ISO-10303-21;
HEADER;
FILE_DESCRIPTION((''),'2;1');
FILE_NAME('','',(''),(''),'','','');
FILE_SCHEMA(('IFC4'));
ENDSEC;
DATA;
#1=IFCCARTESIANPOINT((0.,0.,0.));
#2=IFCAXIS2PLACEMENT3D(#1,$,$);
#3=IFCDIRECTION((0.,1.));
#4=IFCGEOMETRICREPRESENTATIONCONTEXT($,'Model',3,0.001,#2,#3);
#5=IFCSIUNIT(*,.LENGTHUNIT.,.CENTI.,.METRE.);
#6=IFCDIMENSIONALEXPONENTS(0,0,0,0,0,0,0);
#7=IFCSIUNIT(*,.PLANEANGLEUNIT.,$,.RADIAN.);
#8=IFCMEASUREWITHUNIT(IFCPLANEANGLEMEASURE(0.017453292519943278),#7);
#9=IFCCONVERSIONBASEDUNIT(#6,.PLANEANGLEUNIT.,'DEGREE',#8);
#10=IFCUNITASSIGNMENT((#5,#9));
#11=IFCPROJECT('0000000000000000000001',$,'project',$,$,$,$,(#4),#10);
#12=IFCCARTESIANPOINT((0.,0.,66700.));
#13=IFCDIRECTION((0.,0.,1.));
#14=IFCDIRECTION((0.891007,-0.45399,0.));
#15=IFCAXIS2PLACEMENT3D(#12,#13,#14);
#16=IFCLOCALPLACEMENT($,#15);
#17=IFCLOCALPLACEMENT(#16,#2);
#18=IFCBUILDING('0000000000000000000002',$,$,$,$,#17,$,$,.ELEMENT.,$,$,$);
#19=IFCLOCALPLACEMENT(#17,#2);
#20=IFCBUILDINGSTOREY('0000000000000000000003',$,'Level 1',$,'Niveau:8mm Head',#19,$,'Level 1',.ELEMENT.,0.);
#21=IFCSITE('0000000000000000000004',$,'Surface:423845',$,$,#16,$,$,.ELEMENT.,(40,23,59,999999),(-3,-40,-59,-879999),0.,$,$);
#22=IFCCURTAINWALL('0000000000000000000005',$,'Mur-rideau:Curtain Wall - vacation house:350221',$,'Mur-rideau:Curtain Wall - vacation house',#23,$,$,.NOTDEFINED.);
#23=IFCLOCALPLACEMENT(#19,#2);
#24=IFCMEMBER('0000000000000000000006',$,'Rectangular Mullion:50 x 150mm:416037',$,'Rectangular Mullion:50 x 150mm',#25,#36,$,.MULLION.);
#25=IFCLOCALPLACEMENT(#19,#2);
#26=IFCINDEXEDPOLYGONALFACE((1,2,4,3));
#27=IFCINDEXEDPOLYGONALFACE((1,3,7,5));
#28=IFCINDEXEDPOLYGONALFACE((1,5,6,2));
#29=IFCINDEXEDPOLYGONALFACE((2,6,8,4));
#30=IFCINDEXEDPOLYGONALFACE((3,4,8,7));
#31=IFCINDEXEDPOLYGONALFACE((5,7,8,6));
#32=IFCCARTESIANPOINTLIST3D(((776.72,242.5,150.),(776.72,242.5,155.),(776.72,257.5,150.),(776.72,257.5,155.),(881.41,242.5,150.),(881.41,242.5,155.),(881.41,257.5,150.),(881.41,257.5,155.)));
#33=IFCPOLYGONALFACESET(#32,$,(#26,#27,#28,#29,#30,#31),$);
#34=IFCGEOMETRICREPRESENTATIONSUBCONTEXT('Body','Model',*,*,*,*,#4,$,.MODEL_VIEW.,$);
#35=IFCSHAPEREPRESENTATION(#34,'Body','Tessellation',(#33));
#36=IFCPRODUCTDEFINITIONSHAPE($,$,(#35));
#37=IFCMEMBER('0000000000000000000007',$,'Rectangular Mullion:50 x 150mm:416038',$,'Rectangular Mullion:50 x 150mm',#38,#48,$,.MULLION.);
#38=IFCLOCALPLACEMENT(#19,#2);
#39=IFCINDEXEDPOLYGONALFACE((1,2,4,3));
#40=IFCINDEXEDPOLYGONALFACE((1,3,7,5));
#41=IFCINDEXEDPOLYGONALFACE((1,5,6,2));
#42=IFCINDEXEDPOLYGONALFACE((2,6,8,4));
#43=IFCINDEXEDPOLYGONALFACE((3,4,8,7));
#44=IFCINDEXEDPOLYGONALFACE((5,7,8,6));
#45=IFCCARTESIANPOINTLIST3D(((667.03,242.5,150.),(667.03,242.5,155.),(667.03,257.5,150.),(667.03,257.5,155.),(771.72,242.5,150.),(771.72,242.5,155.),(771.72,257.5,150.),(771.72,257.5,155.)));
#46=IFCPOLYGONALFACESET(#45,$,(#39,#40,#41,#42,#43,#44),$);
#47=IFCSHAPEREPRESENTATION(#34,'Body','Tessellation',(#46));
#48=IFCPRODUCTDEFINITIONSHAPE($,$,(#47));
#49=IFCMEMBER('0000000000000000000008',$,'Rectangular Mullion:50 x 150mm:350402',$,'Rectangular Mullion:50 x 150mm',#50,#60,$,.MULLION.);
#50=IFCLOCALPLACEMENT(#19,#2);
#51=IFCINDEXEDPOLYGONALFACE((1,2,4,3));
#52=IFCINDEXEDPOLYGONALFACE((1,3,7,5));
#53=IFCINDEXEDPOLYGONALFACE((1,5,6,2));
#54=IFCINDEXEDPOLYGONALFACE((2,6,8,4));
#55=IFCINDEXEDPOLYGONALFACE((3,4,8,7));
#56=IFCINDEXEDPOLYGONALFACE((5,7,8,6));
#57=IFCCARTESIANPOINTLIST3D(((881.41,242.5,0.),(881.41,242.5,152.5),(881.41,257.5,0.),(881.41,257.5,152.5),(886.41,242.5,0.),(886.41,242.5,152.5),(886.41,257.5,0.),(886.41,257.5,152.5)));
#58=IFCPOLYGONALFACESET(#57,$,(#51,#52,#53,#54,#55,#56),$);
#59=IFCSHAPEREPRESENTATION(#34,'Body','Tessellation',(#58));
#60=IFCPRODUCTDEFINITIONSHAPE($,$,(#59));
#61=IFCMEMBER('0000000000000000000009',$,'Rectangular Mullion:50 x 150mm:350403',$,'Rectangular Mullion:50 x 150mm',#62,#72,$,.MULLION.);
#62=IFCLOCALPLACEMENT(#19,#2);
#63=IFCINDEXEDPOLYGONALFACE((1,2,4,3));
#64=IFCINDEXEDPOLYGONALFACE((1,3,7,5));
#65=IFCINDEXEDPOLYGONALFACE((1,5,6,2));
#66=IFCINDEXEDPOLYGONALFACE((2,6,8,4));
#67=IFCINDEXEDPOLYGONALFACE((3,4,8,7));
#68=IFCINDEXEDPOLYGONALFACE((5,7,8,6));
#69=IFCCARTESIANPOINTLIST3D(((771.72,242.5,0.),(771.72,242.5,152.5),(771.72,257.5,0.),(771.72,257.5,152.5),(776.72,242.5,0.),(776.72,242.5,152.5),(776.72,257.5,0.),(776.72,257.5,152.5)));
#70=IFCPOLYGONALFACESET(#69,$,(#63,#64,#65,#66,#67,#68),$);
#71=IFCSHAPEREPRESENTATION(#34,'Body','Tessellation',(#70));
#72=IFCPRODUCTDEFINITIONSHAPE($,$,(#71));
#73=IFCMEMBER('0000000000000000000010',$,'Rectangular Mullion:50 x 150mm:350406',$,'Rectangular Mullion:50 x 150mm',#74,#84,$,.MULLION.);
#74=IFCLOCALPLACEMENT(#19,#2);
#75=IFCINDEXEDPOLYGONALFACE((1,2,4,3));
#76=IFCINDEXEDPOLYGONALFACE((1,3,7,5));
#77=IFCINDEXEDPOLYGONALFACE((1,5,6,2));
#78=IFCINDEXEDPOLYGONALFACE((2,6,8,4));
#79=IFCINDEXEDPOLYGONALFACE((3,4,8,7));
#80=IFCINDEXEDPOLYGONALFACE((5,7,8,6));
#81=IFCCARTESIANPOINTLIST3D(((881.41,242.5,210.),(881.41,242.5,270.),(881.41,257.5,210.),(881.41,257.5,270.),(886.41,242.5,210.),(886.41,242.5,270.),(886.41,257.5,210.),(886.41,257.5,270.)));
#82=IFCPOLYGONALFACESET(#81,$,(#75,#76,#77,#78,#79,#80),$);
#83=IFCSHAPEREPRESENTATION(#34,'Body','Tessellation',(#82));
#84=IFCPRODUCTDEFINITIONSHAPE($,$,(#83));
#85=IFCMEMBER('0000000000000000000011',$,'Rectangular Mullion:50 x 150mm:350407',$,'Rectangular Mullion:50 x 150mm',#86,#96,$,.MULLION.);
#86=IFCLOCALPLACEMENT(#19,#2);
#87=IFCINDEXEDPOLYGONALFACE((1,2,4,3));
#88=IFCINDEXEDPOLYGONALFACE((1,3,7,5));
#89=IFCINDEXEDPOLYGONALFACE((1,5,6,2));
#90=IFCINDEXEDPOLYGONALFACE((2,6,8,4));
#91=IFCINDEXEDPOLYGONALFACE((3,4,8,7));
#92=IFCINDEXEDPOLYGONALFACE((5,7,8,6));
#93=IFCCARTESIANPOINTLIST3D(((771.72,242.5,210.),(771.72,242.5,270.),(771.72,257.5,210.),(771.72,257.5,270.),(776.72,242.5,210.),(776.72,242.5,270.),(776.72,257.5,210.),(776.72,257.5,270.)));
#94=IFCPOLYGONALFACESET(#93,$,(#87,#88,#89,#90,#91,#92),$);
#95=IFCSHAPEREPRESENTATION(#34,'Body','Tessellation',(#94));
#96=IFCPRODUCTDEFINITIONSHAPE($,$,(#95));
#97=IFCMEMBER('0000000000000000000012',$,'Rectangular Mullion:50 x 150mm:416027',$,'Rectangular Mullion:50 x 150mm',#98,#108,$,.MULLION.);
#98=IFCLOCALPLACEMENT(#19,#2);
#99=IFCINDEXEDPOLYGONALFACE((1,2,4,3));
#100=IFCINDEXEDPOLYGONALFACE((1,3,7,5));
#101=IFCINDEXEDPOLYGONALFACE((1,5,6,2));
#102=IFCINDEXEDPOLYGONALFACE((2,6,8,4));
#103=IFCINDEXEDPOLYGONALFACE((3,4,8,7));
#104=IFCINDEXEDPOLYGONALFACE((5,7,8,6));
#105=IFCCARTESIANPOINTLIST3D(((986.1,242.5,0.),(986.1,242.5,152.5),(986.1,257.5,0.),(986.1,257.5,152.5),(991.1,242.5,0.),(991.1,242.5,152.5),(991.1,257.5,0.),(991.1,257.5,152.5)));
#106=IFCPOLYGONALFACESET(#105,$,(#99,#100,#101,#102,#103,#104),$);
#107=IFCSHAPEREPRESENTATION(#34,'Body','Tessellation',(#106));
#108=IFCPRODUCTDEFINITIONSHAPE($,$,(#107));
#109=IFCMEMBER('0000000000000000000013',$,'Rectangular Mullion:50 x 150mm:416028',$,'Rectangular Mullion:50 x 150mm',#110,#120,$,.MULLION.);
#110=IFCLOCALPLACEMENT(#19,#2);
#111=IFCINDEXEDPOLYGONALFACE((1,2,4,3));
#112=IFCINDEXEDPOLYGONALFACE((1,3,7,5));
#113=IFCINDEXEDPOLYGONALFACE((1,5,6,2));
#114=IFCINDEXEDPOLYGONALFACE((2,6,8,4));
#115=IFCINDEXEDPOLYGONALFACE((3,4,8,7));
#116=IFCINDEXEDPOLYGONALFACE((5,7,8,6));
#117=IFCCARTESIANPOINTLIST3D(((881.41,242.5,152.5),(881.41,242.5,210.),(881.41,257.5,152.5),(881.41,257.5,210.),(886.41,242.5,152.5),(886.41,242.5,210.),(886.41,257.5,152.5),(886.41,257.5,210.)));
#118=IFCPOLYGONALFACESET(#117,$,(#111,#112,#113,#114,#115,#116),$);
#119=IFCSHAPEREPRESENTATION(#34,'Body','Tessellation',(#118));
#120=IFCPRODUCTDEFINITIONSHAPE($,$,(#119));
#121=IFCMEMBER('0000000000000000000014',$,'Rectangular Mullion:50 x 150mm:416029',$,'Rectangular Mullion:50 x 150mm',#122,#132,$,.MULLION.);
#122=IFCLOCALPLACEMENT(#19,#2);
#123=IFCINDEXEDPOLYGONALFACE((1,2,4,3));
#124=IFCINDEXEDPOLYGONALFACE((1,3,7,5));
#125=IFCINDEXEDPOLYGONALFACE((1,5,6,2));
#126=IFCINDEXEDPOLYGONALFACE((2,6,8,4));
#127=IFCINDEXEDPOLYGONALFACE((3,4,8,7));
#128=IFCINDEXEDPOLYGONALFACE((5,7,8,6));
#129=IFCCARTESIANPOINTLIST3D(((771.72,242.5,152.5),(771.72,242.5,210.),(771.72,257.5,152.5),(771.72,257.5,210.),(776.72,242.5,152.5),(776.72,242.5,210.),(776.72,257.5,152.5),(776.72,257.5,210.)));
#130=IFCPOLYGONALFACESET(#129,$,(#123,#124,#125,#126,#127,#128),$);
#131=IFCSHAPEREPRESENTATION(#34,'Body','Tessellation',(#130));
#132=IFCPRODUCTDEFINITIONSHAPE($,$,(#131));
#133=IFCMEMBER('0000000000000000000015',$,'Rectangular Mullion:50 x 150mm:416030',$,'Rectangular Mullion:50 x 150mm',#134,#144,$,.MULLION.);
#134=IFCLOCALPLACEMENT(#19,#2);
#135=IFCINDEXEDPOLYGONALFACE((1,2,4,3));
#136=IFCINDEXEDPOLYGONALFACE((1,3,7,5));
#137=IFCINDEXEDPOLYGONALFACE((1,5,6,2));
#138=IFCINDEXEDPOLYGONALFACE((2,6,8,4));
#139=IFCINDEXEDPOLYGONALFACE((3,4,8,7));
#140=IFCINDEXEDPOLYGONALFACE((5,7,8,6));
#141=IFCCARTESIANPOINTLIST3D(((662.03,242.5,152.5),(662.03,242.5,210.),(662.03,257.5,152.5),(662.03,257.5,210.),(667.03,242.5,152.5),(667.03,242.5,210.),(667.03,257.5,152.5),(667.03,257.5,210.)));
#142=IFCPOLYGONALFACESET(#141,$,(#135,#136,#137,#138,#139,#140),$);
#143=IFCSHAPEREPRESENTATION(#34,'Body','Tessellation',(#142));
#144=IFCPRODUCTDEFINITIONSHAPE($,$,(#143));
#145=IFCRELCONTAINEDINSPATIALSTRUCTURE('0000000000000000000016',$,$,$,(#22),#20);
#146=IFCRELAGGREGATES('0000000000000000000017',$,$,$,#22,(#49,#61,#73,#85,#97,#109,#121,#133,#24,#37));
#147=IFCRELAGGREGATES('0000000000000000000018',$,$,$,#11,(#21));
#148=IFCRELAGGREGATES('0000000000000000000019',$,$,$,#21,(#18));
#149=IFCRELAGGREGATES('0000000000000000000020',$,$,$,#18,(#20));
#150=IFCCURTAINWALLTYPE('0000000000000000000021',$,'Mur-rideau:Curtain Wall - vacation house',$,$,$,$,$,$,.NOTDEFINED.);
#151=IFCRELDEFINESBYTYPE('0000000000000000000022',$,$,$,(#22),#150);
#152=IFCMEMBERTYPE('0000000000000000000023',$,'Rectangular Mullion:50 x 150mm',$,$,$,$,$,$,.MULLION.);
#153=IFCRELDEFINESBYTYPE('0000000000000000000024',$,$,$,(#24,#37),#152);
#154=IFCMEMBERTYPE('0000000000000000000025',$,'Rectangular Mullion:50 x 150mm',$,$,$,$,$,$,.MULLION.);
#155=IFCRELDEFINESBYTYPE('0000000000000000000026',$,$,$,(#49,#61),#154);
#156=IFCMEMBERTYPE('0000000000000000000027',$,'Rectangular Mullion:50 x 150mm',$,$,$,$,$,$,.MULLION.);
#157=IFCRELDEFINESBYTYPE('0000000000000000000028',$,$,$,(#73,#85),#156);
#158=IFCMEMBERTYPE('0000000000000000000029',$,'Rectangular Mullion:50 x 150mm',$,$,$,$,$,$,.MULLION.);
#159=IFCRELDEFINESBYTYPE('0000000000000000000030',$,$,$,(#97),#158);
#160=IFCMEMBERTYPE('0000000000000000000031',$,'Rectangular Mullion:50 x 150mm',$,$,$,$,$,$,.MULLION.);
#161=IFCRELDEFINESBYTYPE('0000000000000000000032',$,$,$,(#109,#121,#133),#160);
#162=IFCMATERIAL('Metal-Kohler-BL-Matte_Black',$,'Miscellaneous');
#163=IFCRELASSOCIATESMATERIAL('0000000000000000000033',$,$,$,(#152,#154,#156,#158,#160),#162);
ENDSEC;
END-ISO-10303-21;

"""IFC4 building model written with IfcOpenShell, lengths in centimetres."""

from ifc_helpers import new_model, entity, si_unit, converted_unit, direction, frame, origin, origin_2d_with_axis, place, context, subcontext, project, spatial, rectangle, extrude, source, transform, mapped, material, material_profile, profile_set, type_object, type_shapes, element, aggregate, save


model = new_model("IFC4")

# Units and contexts
model_context = context("Model", 3, precision=0.001, world=origin(), true_north=direction((0.0, 1.0)))
body_context = subcontext(model_context, "Body", "Model", "MODEL_VIEW")
ifc_project = project(units=[si_unit("LENGTHUNIT", "METRE", prefix="CENTI"), converted_unit("PLANEANGLEUNIT", "DEGREE", entity("IfcPlaneAngleMeasure", 0.017453292519943278), si_unit("PLANEANGLEUNIT", "RADIAN"), dimensions=[0, 0, 0, 0, 0, 0, 0])], contexts=[model_context])

# Site, building, storey
site_placement = place(None, frame((0.0, 0.0, 66700.0), z_axis=(0.0, 0.0, 1.0), x_axis=(0.891007, -0.45399, 0.0)))
site = spatial("IfcSite", under=ifc_project, at=site_placement, Name="Surface:423845", CompositionType="ELEMENT", RefLatitude=(40, 23, 59, 999999), RefLongitude=(-3, -40, -59, -879999), RefElevation=0.0)
building_placement = place(site_placement, origin())
building = spatial("IfcBuilding", under=site, at=building_placement, CompositionType="ELEMENT")
storey_placement = place(building_placement, origin())
storey = spatial("IfcBuildingStorey", under=building, at=storey_placement, Name="Level 1", ObjectType="Niveau:8mm Head", LongName="Level 1", CompositionType="ELEMENT", Elevation=0.0)

# Curtain wall, members
curtain_wall_type = type_object("IfcCurtainWallType", Name="Mur-rideau:Curtain Wall - vacation house", PredefinedType="NOTDEFINED")
curtain_wall_placement = place(storey_placement, origin())
curtain_wall = element("IfcCurtainWall", 1, at=curtain_wall_placement, inside=storey, type_object=curtain_wall_type, Name="Mur-rideau:Curtain Wall - vacation house:350221", ObjectType="Mur-rideau:Curtain Wall - vacation house", PredefinedType="NOTDEFINED")
ifc_material_1 = material(Name="Metal-Kohler-BL-Matte_Black", Category="Miscellaneous")
ifc_material_profile = material_profile(ifc_material_1, rectangle(XDim=5.0, YDim=15.0, at=origin_2d_with_axis()), Name="50 x 150mm")
ifc_profile_set = profile_set([ifc_material_profile], Name="50 x 150mm")
member_type_1 = type_object("IfcMemberType", Name="Rectangular Mullion:50 x 150mm", PredefinedType="MULLION", material=ifc_profile_set)
shared_shape_1 = source(origin(), body_context, "Body", "SweptSolid", [
    extrude(rectangle(XDim=5.0, YDim=15.0, at=origin_2d_with_axis()), frame((0.0, 0.0, -104.69), z_axis=(0.0, 0.0, 1.0), x_axis=(-1.0, 0.0, 0.0)), (0.0, 0.0, 1.0), 104.69),
])
type_shapes(member_type_1, [shared_shape_1])
member_1_placement = place(curtain_wall_placement, frame((776.72, 250.0, 152.5), z_axis=(-1.0, 0.0, 0.0), x_axis=(0.0, 0.0, 1.0)))
member_1 = element("IfcMember", 2, at=member_1_placement, type_object=member_type_1, Name="Rectangular Mullion:50 x 150mm:416037", ObjectType="Rectangular Mullion:50 x 150mm", PredefinedType="MULLION", context=body_context, shape_type="MappedRepresentation", body=[
    mapped(shared_shape_1, transform((0.0, 0.0, 0.0), scale=1.0)),
])
member_2_placement = place(curtain_wall_placement, frame((667.03, 250.0, 152.5), z_axis=(-1.0, 0.0, 0.0), x_axis=(0.0, 0.0, 1.0)))
member_2 = element("IfcMember", 3, at=member_2_placement, type_object=member_type_1, Name="Rectangular Mullion:50 x 150mm:416038", ObjectType="Rectangular Mullion:50 x 150mm", PredefinedType="MULLION", context=body_context, shape_type="MappedRepresentation", body=[
    mapped(shared_shape_1, transform((0.0, 0.0, 0.0), scale=1.0)),
])
member_type_2 = type_object("IfcMemberType", Name="Rectangular Mullion:50 x 150mm", PredefinedType="MULLION", material=ifc_profile_set)
shared_shape_2 = source(origin(), body_context, "Body", "SweptSolid", [
    extrude(rectangle(XDim=5.0, YDim=15.0, at=origin_2d_with_axis()), frame((0.0, 0.0, -152.5), z_axis=(0.0, 0.0, 1.0), x_axis=(-1.0, 0.0, 0.0)), (0.0, 0.0, 1.0), 152.5),
])
type_shapes(member_type_2, [shared_shape_2])
member_3_placement = place(curtain_wall_placement, frame((883.91, 250.0, 0.0), z_axis=(0.0, 0.0, -1.0), x_axis=(-1.0, 0.0, 0.0)))
member_3 = element("IfcMember", 4, at=member_3_placement, type_object=member_type_2, Name="Rectangular Mullion:50 x 150mm:350402", ObjectType="Rectangular Mullion:50 x 150mm", PredefinedType="MULLION", context=body_context, shape_type="MappedRepresentation", body=[
    mapped(shared_shape_2, transform((0.0, 0.0, 0.0), scale=1.0)),
])
member_4_placement = place(curtain_wall_placement, frame((774.22, 250.0, 0.0), z_axis=(0.0, 0.0, -1.0), x_axis=(-1.0, 0.0, 0.0)))
member_4 = element("IfcMember", 5, at=member_4_placement, type_object=member_type_2, Name="Rectangular Mullion:50 x 150mm:350403", ObjectType="Rectangular Mullion:50 x 150mm", PredefinedType="MULLION", context=body_context, shape_type="MappedRepresentation", body=[
    mapped(shared_shape_2, transform((0.0, 0.0, 0.0), scale=1.0)),
])
member_type_3 = type_object("IfcMemberType", Name="Rectangular Mullion:50 x 150mm", PredefinedType="MULLION", material=ifc_profile_set)
shared_shape_3 = source(origin(), body_context, "Body", "SweptSolid", [
    extrude(rectangle(XDim=5.0, YDim=15.0, at=origin_2d_with_axis()), frame((0.0, 0.0, -60.0), z_axis=(0.0, 0.0, 1.0), x_axis=(-1.0, 0.0, 0.0)), (0.0, 0.0, 1.0), 60.0),
])
type_shapes(member_type_3, [shared_shape_3])
member_5_placement = place(curtain_wall_placement, frame((883.91, 250.0, 210.0), z_axis=(0.0, 0.0, -1.0), x_axis=(-1.0, 0.0, 0.0)))
member_5 = element("IfcMember", 6, at=member_5_placement, type_object=member_type_3, Name="Rectangular Mullion:50 x 150mm:350406", ObjectType="Rectangular Mullion:50 x 150mm", PredefinedType="MULLION", context=body_context, shape_type="MappedRepresentation", body=[
    mapped(shared_shape_3, transform((0.0, 0.0, 0.0), scale=1.0)),
])
member_6_placement = place(curtain_wall_placement, frame((774.22, 250.0, 210.0), z_axis=(0.0, 0.0, -1.0), x_axis=(-1.0, 0.0, 0.0)))
member_6 = element("IfcMember", 7, at=member_6_placement, type_object=member_type_3, Name="Rectangular Mullion:50 x 150mm:350407", ObjectType="Rectangular Mullion:50 x 150mm", PredefinedType="MULLION", context=body_context, shape_type="MappedRepresentation", body=[
    mapped(shared_shape_3, transform((0.0, 0.0, 0.0), scale=1.0)),
])
member_type_4 = type_object("IfcMemberType", Name="Rectangular Mullion:50 x 150mm", PredefinedType="MULLION", material=ifc_profile_set)
shared_shape_4 = source(origin(), body_context, "Body", "SweptSolid", [
    extrude(rectangle(XDim=5.0, YDim=15.0, at=origin_2d_with_axis()), frame((-2.5, 0.0, -152.5), z_axis=(0.0, 0.0, 1.0), x_axis=(-1.0, 0.0, 0.0)), (0.0, 0.0, 1.0), 152.5),
])
type_shapes(member_type_4, [shared_shape_4])
member_7_placement = place(curtain_wall_placement, frame((991.1, 250.0, 152.5)))
member_7 = element("IfcMember", 8, at=member_7_placement, type_object=member_type_4, Name="Rectangular Mullion:50 x 150mm:416027", ObjectType="Rectangular Mullion:50 x 150mm", PredefinedType="MULLION", context=body_context, shape_type="MappedRepresentation", body=[
    mapped(shared_shape_4, transform((0.0, 0.0, 0.0), scale=1.0)),
])
member_type_5 = type_object("IfcMemberType", Name="Rectangular Mullion:50 x 150mm", PredefinedType="MULLION", material=ifc_profile_set)
shared_shape_5 = source(origin(), body_context, "Body", "SweptSolid", [
    extrude(rectangle(XDim=5.0, YDim=15.0, at=origin_2d_with_axis()), frame((0.0, 0.0, -57.5), z_axis=(0.0, 0.0, 1.0), x_axis=(-1.0, 0.0, 0.0)), (0.0, 0.0, 1.0), 57.5),
])
type_shapes(member_type_5, [shared_shape_5])
member_8_placement = place(curtain_wall_placement, frame((883.91, 250.0, 152.5), z_axis=(0.0, 0.0, -1.0), x_axis=(-1.0, 0.0, 0.0)))
member_8 = element("IfcMember", 9, at=member_8_placement, type_object=member_type_5, Name="Rectangular Mullion:50 x 150mm:416028", ObjectType="Rectangular Mullion:50 x 150mm", PredefinedType="MULLION", context=body_context, shape_type="MappedRepresentation", body=[
    mapped(shared_shape_5, transform((0.0, 0.0, 0.0), scale=1.0)),
])
member_9_placement = place(curtain_wall_placement, frame((774.22, 250.0, 152.5), z_axis=(0.0, 0.0, -1.0), x_axis=(-1.0, 0.0, 0.0)))
member_9 = element("IfcMember", 10, at=member_9_placement, type_object=member_type_5, Name="Rectangular Mullion:50 x 150mm:416029", ObjectType="Rectangular Mullion:50 x 150mm", PredefinedType="MULLION", context=body_context, shape_type="MappedRepresentation", body=[
    mapped(shared_shape_5, transform((0.0, 0.0, 0.0), scale=1.0)),
])
member_10_placement = place(curtain_wall_placement, frame((664.53, 250.0, 152.5), z_axis=(0.0, 0.0, -1.0), x_axis=(-1.0, 0.0, 0.0)))
member_10 = element("IfcMember", 11, at=member_10_placement, type_object=member_type_5, Name="Rectangular Mullion:50 x 150mm:416030", ObjectType="Rectangular Mullion:50 x 150mm", PredefinedType="MULLION", context=body_context, shape_type="MappedRepresentation", body=[
    mapped(shared_shape_5, transform((0.0, 0.0, 0.0), scale=1.0)),
])
aggregate(curtain_wall, [member_3, member_4, member_5, member_6, member_7, member_8, member_9, member_10, member_1, member_2])

save(model, "model.ifc")
